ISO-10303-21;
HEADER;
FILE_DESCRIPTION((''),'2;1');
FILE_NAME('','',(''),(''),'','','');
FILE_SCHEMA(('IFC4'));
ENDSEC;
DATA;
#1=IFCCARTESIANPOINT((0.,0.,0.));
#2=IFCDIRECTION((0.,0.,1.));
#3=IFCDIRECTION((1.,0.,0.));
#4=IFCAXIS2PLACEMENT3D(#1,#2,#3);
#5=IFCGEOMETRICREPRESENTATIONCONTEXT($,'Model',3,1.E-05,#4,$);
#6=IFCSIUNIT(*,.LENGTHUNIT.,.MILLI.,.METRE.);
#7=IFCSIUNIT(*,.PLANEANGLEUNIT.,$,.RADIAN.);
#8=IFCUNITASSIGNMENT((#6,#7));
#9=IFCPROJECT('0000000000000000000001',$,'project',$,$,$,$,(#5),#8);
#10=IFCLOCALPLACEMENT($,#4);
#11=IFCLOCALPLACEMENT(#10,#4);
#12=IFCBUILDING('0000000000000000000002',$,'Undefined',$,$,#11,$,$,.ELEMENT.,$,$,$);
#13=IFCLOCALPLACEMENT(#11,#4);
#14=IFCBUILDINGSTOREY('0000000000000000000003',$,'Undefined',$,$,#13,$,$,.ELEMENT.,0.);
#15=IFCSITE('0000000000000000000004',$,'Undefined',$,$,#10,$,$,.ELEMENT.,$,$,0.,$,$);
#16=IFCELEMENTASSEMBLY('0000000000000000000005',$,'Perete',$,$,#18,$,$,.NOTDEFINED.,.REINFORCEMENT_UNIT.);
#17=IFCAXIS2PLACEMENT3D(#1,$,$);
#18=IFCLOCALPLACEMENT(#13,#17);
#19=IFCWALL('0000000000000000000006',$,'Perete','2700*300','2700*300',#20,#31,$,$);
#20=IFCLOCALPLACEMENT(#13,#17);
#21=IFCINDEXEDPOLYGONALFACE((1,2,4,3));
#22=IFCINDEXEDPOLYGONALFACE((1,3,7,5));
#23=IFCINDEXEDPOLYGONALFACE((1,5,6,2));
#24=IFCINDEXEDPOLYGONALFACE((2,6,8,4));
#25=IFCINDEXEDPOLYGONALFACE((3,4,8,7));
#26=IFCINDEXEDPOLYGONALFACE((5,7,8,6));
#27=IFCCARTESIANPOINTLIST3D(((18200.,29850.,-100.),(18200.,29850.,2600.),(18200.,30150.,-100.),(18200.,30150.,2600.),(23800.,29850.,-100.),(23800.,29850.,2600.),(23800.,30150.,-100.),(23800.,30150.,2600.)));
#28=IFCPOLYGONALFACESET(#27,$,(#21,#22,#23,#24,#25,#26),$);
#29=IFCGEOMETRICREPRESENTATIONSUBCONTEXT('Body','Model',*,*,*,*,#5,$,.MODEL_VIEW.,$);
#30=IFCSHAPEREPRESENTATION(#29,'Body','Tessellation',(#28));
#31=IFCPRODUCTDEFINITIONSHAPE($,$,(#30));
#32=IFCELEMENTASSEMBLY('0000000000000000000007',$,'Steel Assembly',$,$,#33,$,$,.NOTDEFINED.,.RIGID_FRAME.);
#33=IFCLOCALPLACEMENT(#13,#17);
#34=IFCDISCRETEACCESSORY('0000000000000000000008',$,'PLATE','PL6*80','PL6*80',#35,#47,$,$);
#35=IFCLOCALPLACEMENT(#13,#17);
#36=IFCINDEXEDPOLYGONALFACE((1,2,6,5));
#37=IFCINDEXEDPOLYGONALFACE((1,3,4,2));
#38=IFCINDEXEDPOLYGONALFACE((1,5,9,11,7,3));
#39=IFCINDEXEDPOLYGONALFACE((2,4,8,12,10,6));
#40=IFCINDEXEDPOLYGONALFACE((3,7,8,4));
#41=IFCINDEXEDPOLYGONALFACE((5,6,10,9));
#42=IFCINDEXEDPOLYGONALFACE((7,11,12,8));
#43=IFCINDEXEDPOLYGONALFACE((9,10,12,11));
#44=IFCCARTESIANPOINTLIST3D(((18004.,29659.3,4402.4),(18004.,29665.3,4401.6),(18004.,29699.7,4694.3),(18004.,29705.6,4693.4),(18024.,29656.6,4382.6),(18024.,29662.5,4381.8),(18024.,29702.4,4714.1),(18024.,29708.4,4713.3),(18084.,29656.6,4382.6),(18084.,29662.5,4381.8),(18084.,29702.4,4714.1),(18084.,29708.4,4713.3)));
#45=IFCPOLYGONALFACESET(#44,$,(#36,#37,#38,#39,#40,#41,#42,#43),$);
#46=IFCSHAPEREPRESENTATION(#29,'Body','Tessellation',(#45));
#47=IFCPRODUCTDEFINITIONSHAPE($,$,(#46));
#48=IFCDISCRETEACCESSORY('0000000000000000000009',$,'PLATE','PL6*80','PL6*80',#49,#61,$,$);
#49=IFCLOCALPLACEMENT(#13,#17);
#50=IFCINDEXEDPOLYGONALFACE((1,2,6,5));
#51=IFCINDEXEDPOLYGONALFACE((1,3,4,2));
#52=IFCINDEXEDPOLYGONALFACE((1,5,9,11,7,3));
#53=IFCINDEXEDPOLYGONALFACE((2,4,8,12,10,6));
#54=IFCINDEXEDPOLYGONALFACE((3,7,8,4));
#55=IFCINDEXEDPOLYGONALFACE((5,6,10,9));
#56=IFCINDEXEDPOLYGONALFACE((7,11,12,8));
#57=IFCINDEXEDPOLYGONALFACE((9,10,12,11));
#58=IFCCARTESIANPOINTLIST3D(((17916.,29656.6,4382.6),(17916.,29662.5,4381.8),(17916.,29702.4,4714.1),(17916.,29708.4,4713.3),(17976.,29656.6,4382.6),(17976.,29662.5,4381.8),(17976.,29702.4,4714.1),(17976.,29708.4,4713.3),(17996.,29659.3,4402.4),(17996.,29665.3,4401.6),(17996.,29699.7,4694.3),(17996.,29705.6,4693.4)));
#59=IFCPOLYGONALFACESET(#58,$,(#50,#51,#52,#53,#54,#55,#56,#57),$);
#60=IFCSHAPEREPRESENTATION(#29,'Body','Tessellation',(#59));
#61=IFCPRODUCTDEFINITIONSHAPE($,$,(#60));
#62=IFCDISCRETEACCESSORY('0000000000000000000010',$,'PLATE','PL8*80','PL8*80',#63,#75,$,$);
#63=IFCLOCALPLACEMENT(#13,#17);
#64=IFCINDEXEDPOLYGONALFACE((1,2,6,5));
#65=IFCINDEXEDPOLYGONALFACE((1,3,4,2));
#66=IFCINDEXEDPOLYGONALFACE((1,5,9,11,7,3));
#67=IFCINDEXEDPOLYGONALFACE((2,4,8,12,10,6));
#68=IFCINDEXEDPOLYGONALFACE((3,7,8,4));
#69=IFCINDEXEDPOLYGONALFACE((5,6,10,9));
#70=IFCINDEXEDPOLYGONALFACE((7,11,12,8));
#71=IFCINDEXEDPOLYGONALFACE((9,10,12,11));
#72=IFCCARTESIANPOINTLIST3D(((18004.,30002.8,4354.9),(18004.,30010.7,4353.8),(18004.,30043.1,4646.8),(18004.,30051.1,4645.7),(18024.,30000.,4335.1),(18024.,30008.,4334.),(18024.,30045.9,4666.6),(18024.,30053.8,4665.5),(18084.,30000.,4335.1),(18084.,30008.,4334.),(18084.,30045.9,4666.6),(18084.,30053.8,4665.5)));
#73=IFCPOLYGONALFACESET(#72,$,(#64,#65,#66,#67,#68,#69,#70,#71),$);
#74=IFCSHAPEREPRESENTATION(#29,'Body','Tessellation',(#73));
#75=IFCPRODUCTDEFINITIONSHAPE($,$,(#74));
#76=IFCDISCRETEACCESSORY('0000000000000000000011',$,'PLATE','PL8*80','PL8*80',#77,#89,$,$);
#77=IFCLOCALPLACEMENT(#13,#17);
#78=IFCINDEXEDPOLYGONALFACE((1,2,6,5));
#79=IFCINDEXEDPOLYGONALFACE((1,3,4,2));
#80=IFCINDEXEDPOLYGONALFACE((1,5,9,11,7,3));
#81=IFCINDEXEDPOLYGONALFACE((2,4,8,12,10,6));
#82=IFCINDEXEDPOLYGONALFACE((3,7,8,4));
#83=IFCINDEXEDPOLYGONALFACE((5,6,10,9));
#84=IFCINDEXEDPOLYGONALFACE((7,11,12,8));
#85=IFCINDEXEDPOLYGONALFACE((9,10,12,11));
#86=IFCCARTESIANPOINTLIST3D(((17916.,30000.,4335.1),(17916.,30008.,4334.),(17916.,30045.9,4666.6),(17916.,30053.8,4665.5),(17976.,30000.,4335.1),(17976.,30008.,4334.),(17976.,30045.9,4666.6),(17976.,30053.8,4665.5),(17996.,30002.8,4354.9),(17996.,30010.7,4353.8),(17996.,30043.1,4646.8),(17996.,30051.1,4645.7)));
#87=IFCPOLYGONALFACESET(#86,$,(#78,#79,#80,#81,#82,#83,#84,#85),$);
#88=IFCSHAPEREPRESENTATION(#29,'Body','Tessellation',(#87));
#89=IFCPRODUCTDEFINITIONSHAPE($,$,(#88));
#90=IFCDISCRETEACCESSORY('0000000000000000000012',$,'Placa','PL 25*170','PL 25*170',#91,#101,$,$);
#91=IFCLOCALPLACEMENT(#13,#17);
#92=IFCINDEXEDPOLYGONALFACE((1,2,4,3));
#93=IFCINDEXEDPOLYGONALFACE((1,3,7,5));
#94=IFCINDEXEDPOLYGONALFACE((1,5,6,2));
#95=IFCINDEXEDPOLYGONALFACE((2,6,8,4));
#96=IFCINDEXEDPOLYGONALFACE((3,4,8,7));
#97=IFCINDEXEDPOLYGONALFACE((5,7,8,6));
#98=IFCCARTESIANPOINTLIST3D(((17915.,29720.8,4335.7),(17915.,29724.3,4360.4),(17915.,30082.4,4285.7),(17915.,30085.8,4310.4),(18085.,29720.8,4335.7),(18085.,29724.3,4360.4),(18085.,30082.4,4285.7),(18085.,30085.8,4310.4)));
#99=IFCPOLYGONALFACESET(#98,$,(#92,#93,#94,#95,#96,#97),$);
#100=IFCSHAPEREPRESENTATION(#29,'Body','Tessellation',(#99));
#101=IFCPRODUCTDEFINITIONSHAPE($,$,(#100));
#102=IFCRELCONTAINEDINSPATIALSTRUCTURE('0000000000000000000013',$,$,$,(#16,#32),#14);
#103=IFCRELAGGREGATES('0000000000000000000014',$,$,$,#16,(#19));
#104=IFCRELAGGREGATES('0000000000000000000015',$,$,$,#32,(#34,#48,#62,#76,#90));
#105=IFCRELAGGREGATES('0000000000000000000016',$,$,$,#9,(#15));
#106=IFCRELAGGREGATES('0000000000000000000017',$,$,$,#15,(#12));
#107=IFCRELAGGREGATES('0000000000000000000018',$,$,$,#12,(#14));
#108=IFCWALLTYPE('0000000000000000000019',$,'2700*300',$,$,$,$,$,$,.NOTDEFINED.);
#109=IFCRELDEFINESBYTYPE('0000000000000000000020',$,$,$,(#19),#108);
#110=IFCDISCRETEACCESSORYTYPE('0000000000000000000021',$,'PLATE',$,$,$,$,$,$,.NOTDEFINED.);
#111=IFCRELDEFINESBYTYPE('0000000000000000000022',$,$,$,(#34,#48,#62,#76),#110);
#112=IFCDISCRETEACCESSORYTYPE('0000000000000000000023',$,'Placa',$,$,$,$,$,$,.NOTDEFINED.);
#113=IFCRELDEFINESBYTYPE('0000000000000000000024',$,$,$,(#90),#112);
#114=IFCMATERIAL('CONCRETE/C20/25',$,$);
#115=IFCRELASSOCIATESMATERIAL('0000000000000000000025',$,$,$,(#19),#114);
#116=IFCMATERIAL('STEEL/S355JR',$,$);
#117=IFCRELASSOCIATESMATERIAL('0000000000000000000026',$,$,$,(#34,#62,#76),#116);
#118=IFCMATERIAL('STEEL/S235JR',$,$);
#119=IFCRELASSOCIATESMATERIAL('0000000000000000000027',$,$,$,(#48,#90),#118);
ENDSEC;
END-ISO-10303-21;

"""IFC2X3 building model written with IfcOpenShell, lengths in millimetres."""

from ifc_helpers import new_model, si_unit, frame, frame_2d, origin_with_axes, place, context, subcontext, project, spatial, polyline, rectangle, outline, extrude, material, type_object, element, aggregate, save


model = new_model("IFC2X3")

# Units and contexts
model_context = context("Model", 3, precision=1e-05, world=origin_with_axes())
body_context = subcontext(model_context, "Body", "Model", "MODEL_VIEW")
ifc_project = project(units=[si_unit("LENGTHUNIT", "METRE", prefix="MILLI"), si_unit("PLANEANGLEUNIT", "RADIAN")], contexts=[model_context])

# Site, building, storey
site_placement = place(None, origin_with_axes())
site = spatial("IfcSite", under=ifc_project, at=site_placement, Name="Undefined", CompositionType="ELEMENT", RefElevation=0.0)
building_placement = place(site_placement, origin_with_axes())
building = spatial("IfcBuilding", under=site, at=building_placement, Name="Undefined", CompositionType="ELEMENT")
storey_placement = place(building_placement, origin_with_axes())
storey = spatial("IfcBuildingStorey", under=building, at=storey_placement, Name="Undefined", CompositionType="ELEMENT", Elevation=0.0)

# Shared definitions
ifc_material_1 = material(Name="CONCRETE/C20/25")

# Shared definitions
ifc_material_2 = material(Name="STEEL/S355JR")

# Shared definitions
ifc_material_3 = material(Name="STEEL/S235JR")

# Element assembly, wall
assembly_1_placement = place(storey_placement, origin_with_axes())
assembly_1 = element("IfcElementAssembly", 1, at=assembly_1_placement, inside=storey, Name="Perete", AssemblyPlace="NOTDEFINED", PredefinedType="REINFORCEMENT_UNIT")
wall_type = type_object("IfcWallType", Name="2700*300", PredefinedType="NOTDEFINED")
wall_placement = place(assembly_1_placement, frame((18200.0, 30000.0, -100.0), z_axis=(0.0, 0.0, 1.0), x_axis=(1.0, 0.0, 0.0)))
wall = element("IfcWall", 2, at=wall_placement, type_object=wall_type, material=ifc_material_1, Name="Perete", Description="2700*300", ObjectType="2700*300", context=body_context, shape_type="SweptSolid", body=[
    extrude(rectangle(XDim=5600.0, YDim=300.0, at=frame_2d((0.0, 2800.0), x_axis=(0.0, -1.0))), frame((0.0, 0.0, 0.0), z_axis=(0.0, 0.0, 1.0), x_axis=(0.0, -1.0, 0.0)), (0.0, 0.0, 1.0), 2700.0),
])
aggregate(assembly_1, [wall])

# Element assembly, discrete accessories
assembly_2_placement = place(storey_placement, origin_with_axes())
assembly_2 = element("IfcElementAssembly", 3, at=assembly_2_placement, inside=storey, Name="Steel Assembly", AssemblyPlace="NOTDEFINED", PredefinedType="RIGID_FRAME")
discrete_accessory_type_1 = type_object("IfcDiscreteAccessoryType", Name="PLATE")
discrete_accessory_1_placement = place(assembly_2_placement, frame((18084.0, 29659.6, 4382.2), z_axis=(0.0, 0.990574, -0.13698), x_axis=(-1.0, 0.0, 0.0)))
discrete_accessory_1 = element("IfcDiscreteAccessory", 4, at=discrete_accessory_1_placement, type_object=discrete_accessory_type_1, material=ifc_material_2, Name="PLATE", Description="PL6*80", ObjectType="PL6*80", context=body_context, shape_type="SweptSolid", body=[
    extrude(outline(polyline([(0.0, 0.0), (60.0, 0.0), (80.0, 20.0), (80.0, 314.6), (60.0, 334.6), (0.0, 334.6), (0.0, 0.0)])), frame((0.0, 0.0, -3.0), z_axis=(0.0, 0.0, 1.0), x_axis=(1.0, 0.0, 0.0)), (0.0, 0.0, 1.0), 6.0),
])
discrete_accessory_2_placement = place(assembly_2_placement, frame((17996.0, 29659.6, 4382.2), z_axis=(0.0, 0.990574, -0.13698), x_axis=(-1.0, 0.0, 0.0)))
discrete_accessory_2 = element("IfcDiscreteAccessory", 5, at=discrete_accessory_2_placement, type_object=discrete_accessory_type_1, material=ifc_material_3, Name="PLATE", Description="PL6*80", ObjectType="PL6*80", context=body_context, shape_type="SweptSolid", body=[
    extrude(outline(polyline([(0.0, 20.0), (20.0, 0.0), (80.0, 0.0), (80.0, 334.6), (20.0, 334.6), (0.0, 314.6), (0.0, 20.0)])), frame((0.0, 0.0, -3.0), z_axis=(0.0, 0.0, 1.0), x_axis=(1.0, 0.0, 0.0)), (0.0, 0.0, 1.0), 6.0),
])
discrete_accessory_3_placement = place(assembly_2_placement, frame((18084.0, 30004.0, 4334.6), z_axis=(0.0, 0.990574, -0.13698), x_axis=(-1.0, 0.0, 0.0)))
discrete_accessory_3 = element("IfcDiscreteAccessory", 6, at=discrete_accessory_3_placement, type_object=discrete_accessory_type_1, material=ifc_material_2, Name="PLATE", Description="PL8*80", ObjectType="PL8*80", context=body_context, shape_type="SweptSolid", body=[
    extrude(outline(polyline([(0.0, 0.0), (60.0, 0.0), (80.0, 20.0), (80.0, 314.6), (60.0, 334.6), (0.0, 334.6), (0.0, 0.0)])), frame((0.0, 0.0, -4.0), z_axis=(0.0, 0.0, 1.0), x_axis=(1.0, 0.0, 0.0)), (0.0, 0.0, 1.0), 8.0),
])
discrete_accessory_4_placement = place(assembly_2_placement, frame((17996.0, 30004.0, 4334.6), z_axis=(0.0, 0.990574, -0.13698), x_axis=(-1.0, 0.0, 0.0)))
discrete_accessory_4 = element("IfcDiscreteAccessory", 7, at=discrete_accessory_4_placement, type_object=discrete_accessory_type_1, material=ifc_material_2, Name="PLATE", Description="PL8*80", ObjectType="PL8*80", context=body_context, shape_type="SweptSolid", body=[
    extrude(outline(polyline([(0.0, 20.0), (20.0, 0.0), (80.0, 0.0), (80.0, 334.6), (20.0, 334.6), (0.0, 314.6), (0.0, 20.0)])), frame((0.0, 0.0, -4.0), z_axis=(0.0, 0.0, 1.0), x_axis=(1.0, 0.0, 0.0)), (0.0, 0.0, 1.0), 8.0),
])

# Discrete accessory
discrete_accessory_type_2 = type_object("IfcDiscreteAccessoryType", Name="Placa")
discrete_accessory_5_placement = place(assembly_2_placement, frame((18085.0, 30084.1, 4298.1), z_axis=(0.0, -0.13698, -0.990574), x_axis=(0.0, -0.990574, 0.13698)))
discrete_accessory_5 = element("IfcDiscreteAccessory", 8, at=discrete_accessory_5_placement, type_object=discrete_accessory_type_2, material=ifc_material_3, Name="Placa", Description="PL 25*170", ObjectType="PL 25*170", context=body_context, shape_type="SweptSolid", body=[
    extrude(outline(polyline([(0.0, 0.0), (365.0, 0.0), (365.0, 170.0), (0.0, 170.0), (0.0, 0.0)])), frame((0.0, 0.0, -12.5), z_axis=(0.0, 0.0, 1.0), x_axis=(1.0, 0.0, 0.0)), (0.0, 0.0, 1.0), 25.0),
])

aggregate(assembly_2, [discrete_accessory_1, discrete_accessory_2, discrete_accessory_3, discrete_accessory_4, discrete_accessory_5])

save(model, "model.ifc")
